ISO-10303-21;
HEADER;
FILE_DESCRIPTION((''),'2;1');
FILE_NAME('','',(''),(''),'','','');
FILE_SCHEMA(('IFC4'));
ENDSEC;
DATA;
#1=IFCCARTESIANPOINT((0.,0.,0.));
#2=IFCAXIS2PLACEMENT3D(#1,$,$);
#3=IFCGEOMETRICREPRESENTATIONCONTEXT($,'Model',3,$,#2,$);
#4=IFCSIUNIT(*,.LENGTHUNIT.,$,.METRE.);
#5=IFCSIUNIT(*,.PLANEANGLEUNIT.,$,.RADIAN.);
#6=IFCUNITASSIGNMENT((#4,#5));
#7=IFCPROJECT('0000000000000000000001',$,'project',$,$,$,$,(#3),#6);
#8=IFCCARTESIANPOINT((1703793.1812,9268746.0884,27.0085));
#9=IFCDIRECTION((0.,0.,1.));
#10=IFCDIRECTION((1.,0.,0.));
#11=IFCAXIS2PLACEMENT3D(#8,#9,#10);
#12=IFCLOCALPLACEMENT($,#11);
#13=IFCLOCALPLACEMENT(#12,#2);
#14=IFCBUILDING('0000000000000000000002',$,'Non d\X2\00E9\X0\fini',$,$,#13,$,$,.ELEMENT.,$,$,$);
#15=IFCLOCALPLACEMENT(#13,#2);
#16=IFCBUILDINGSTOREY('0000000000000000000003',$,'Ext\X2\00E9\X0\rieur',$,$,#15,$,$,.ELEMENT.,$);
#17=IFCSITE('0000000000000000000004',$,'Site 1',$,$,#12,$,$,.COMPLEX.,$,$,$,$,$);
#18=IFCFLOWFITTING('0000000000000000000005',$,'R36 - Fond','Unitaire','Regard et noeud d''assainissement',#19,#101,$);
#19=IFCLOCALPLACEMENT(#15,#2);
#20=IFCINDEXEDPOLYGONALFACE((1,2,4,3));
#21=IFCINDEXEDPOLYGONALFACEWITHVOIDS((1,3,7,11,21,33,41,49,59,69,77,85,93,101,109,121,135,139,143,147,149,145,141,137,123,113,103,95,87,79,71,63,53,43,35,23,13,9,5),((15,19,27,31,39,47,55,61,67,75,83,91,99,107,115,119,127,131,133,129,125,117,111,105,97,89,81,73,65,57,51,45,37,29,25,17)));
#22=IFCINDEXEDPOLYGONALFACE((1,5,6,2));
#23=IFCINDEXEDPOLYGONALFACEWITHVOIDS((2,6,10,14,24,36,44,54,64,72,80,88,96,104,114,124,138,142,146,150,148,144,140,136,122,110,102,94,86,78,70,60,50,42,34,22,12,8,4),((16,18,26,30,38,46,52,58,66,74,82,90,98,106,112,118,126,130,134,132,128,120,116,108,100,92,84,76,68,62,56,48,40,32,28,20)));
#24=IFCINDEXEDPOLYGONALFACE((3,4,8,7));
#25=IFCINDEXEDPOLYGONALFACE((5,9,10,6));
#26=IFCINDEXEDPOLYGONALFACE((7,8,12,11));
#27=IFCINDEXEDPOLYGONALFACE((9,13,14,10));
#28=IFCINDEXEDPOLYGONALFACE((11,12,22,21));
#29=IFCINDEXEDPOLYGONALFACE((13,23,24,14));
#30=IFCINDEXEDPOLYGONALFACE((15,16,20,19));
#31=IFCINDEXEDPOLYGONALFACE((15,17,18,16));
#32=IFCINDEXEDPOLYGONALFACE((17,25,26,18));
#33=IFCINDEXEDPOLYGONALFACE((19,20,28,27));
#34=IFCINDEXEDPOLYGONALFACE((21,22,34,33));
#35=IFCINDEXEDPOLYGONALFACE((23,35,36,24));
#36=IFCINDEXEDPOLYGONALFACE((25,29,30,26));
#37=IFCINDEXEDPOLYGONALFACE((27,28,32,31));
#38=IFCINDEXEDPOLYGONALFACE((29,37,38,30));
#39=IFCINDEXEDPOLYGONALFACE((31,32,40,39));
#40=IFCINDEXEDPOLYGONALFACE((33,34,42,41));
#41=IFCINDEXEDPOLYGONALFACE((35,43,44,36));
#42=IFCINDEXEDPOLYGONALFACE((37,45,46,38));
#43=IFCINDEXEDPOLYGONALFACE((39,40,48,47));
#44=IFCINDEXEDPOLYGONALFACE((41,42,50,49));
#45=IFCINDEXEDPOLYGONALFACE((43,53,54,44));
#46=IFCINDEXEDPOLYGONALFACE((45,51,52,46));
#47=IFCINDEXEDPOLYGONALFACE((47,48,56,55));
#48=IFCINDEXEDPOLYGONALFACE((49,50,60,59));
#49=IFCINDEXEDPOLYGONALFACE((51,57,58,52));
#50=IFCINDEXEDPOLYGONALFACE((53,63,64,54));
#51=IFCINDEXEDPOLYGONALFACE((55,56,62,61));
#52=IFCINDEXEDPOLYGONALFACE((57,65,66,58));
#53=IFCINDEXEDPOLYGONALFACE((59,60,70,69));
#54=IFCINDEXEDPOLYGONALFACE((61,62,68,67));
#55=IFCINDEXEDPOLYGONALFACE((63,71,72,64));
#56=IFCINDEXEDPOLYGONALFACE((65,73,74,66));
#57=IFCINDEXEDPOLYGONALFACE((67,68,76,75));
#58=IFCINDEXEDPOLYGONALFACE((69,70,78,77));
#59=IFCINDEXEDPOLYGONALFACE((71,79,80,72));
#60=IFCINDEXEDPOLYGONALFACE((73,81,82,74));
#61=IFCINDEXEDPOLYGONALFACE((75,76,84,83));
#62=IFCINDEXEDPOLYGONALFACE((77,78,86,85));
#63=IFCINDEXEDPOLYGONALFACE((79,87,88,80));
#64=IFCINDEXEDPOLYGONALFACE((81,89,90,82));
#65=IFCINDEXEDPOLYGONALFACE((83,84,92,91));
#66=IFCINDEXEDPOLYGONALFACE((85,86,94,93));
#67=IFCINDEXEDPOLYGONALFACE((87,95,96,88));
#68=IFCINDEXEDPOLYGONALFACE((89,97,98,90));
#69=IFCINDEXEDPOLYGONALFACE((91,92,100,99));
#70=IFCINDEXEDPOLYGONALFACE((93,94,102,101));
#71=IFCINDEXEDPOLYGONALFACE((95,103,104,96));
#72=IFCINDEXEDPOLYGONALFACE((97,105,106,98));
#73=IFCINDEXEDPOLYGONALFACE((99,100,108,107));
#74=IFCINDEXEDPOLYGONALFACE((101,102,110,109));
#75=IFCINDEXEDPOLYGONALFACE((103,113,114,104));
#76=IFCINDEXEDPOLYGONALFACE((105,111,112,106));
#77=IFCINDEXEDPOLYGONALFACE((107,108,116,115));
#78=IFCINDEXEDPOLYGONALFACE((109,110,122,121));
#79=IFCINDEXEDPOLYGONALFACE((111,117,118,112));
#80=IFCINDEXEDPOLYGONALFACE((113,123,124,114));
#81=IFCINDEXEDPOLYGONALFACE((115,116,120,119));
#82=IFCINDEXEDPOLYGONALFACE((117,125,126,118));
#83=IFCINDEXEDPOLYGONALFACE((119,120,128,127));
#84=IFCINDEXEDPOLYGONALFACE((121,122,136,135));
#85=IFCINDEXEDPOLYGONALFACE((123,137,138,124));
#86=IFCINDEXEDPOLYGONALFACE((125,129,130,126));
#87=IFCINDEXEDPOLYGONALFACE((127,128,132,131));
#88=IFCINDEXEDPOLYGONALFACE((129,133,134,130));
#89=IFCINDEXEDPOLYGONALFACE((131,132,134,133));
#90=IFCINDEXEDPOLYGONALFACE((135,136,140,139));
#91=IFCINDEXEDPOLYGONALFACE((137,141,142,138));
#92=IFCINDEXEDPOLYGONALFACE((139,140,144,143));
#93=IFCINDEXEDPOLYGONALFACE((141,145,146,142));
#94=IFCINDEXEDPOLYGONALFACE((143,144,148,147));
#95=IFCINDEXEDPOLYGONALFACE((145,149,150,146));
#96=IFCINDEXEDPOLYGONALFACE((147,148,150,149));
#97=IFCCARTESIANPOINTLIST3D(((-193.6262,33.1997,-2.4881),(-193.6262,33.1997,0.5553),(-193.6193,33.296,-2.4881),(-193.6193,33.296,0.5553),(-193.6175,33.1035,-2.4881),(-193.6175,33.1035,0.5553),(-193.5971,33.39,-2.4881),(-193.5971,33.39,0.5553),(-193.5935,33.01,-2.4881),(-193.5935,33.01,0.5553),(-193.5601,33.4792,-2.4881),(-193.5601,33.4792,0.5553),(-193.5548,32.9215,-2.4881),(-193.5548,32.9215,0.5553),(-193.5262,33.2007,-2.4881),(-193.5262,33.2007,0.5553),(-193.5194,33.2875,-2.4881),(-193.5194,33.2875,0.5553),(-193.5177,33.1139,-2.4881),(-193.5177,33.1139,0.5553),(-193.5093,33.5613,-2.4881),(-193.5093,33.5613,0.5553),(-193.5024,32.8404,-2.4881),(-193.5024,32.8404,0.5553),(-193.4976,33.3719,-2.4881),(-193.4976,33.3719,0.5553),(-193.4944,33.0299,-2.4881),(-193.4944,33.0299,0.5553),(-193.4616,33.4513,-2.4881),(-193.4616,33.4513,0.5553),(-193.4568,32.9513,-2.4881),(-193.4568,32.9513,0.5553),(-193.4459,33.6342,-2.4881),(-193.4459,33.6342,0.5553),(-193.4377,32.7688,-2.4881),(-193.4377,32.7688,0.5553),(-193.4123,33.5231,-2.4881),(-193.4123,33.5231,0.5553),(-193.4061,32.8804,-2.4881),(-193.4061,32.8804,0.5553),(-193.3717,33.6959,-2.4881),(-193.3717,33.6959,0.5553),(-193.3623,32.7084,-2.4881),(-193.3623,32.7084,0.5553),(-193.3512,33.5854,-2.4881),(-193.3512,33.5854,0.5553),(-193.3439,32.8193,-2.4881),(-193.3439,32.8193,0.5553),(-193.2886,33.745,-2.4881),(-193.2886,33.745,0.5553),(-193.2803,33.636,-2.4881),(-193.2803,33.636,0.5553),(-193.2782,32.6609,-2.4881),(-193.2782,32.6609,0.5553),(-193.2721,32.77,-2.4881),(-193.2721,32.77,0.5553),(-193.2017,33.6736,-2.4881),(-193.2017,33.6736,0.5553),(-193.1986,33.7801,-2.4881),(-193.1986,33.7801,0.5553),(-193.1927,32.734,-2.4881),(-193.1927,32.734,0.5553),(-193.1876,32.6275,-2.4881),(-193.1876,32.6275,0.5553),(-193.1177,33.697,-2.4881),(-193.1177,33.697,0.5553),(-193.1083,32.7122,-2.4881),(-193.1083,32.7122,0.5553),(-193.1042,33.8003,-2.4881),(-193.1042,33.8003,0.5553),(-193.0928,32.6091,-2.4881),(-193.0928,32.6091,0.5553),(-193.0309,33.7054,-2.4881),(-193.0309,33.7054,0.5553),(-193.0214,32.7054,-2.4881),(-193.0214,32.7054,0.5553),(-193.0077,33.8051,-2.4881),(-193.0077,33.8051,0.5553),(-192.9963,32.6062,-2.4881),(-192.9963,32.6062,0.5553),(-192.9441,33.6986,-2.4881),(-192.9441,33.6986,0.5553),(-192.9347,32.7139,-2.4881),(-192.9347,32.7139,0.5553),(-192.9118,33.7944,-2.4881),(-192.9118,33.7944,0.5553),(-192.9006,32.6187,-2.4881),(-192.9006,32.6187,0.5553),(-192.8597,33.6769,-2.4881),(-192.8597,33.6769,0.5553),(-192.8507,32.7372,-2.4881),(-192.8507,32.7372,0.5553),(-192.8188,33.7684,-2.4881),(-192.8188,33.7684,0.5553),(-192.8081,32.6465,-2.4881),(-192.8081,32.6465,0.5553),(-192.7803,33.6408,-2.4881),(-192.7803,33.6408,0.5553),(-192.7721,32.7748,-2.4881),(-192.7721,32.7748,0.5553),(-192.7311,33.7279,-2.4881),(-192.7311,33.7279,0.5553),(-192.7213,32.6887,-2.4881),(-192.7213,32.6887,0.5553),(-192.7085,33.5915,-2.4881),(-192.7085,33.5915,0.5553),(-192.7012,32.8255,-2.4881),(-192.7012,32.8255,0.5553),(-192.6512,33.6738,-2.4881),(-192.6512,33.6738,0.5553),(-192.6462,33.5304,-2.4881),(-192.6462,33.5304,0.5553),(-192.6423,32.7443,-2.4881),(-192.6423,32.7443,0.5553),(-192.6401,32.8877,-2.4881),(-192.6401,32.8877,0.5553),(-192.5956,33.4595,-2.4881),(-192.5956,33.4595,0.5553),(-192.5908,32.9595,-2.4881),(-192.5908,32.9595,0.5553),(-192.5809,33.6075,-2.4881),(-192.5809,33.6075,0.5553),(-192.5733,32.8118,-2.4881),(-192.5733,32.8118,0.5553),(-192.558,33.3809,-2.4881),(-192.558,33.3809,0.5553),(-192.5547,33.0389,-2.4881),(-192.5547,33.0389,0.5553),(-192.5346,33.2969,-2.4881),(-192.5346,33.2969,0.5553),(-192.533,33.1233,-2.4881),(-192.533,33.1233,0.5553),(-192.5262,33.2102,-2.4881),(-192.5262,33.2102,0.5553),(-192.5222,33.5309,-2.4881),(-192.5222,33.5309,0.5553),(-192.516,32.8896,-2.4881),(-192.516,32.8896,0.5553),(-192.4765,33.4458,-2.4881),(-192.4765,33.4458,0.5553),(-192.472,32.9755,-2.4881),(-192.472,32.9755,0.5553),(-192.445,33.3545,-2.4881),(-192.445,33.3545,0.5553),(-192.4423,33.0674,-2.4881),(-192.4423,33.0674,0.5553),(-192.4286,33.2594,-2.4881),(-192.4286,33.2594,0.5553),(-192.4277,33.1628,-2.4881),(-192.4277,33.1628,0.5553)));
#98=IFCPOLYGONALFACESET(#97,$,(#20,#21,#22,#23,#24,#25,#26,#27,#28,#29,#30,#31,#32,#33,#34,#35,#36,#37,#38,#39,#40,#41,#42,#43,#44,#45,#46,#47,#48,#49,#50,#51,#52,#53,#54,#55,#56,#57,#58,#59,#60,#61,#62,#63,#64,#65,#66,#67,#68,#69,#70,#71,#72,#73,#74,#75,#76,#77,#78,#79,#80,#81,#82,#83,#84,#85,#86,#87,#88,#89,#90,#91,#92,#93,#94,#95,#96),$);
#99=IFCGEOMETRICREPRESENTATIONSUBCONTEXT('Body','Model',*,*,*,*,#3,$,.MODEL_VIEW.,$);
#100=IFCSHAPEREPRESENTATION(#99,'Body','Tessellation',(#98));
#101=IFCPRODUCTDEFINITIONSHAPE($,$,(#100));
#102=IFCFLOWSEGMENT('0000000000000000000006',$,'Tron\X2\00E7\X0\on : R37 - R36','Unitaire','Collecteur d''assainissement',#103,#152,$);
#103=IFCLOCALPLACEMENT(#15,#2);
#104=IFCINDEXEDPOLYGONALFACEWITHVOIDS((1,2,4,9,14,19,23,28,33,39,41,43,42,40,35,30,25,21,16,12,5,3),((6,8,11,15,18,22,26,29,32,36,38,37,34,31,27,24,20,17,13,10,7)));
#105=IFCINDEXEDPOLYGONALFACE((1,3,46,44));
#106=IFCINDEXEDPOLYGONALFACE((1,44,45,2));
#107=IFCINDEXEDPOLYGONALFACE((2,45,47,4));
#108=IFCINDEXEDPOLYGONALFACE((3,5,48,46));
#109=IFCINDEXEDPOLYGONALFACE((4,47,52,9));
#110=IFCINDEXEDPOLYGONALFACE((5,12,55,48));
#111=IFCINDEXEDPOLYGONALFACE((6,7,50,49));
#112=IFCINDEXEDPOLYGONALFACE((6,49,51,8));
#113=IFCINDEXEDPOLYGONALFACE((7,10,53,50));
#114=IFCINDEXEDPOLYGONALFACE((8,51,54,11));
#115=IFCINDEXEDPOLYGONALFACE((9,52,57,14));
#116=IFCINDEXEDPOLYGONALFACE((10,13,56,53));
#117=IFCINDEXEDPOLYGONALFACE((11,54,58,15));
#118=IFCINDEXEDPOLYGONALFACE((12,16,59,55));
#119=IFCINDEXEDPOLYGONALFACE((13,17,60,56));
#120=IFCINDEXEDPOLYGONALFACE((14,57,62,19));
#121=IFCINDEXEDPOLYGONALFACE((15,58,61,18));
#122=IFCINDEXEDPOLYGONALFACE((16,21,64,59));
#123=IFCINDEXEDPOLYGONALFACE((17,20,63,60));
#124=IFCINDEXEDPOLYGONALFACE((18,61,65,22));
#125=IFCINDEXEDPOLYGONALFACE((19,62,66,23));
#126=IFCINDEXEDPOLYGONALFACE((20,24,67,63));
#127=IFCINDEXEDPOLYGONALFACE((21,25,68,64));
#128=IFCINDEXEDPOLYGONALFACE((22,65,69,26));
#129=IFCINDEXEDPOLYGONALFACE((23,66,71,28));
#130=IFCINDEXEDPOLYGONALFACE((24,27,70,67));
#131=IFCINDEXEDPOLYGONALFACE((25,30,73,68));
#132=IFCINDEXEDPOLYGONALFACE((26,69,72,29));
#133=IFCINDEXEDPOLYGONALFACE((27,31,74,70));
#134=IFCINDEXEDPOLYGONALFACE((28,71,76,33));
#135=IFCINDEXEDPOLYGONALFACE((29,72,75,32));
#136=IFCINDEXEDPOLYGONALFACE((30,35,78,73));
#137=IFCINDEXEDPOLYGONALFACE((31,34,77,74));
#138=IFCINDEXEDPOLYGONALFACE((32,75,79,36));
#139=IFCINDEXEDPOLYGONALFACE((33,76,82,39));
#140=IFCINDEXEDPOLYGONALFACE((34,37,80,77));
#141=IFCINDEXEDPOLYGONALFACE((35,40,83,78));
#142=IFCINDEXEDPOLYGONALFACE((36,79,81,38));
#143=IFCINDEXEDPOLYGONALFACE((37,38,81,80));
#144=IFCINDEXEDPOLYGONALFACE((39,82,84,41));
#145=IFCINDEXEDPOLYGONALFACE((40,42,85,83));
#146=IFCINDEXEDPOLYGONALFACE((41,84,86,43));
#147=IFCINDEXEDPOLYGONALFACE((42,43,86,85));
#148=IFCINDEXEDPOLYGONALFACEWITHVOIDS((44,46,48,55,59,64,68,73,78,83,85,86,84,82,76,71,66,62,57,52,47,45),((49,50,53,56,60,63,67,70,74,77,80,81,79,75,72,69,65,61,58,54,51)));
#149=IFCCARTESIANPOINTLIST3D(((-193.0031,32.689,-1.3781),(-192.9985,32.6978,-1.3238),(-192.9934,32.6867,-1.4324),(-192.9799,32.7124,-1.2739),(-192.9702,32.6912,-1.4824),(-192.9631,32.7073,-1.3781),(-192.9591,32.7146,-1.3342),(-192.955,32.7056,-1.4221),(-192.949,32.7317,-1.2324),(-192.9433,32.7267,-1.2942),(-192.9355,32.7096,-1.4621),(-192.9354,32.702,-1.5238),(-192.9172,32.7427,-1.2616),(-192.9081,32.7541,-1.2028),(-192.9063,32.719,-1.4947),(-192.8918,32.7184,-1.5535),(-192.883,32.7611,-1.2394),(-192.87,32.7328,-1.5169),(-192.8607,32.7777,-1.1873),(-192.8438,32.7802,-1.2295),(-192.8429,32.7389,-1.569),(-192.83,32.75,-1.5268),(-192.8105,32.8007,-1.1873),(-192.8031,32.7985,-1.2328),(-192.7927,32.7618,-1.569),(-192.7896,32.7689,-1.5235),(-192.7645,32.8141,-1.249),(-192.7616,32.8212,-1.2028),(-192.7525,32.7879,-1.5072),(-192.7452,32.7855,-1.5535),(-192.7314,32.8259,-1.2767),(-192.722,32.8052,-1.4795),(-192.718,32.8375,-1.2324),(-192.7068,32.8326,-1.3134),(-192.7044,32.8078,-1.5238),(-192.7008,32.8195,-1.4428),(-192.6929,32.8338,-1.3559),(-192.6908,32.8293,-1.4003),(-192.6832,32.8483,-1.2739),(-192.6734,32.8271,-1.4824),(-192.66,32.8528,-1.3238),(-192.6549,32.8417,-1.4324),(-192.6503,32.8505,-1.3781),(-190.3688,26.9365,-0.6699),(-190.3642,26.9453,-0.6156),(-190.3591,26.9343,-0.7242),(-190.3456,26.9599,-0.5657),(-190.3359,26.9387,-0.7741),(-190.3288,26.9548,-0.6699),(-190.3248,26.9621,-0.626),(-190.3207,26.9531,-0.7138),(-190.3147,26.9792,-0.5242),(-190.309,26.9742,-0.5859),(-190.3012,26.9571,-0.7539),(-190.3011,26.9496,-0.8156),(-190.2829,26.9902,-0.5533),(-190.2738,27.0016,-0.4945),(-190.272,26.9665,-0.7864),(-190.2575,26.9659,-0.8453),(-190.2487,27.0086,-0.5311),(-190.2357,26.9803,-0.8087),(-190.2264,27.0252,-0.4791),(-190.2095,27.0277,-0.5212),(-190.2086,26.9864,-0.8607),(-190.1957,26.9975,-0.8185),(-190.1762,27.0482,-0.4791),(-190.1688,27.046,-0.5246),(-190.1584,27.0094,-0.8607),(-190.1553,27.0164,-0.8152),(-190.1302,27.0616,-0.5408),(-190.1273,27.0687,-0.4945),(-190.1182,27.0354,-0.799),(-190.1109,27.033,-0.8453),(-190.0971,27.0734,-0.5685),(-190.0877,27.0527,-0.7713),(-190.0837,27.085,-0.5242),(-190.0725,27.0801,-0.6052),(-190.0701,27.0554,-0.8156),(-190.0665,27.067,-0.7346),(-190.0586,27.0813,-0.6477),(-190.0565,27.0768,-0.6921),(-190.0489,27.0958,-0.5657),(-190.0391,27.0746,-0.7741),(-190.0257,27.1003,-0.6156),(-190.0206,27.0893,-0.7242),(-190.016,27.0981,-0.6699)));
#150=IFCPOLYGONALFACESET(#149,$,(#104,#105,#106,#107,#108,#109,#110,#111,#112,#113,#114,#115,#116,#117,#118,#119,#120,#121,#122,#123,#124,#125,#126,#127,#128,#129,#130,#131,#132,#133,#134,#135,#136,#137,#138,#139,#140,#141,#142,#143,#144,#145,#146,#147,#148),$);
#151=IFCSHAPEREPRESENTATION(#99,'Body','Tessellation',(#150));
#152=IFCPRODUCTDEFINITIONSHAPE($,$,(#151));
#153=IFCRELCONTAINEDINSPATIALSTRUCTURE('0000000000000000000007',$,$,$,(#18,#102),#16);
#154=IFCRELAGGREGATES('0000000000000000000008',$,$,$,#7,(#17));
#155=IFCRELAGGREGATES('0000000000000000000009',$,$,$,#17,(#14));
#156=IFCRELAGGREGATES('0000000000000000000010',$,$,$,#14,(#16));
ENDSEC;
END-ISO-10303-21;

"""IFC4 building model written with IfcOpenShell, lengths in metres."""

from ifc_helpers import new_model, si_unit, frame, origin, origin_2d, place, context, subcontext, project, spatial, hollow_circle, extrude, element, save


model = new_model("IFC4")

# Units and contexts
model_context = context("Model", 3, world=origin())
body_context = subcontext(model_context, "Body", "Model", "MODEL_VIEW")
ifc_project = project(units=[si_unit("LENGTHUNIT", "METRE"), si_unit("PLANEANGLEUNIT", "RADIAN")], contexts=[model_context])

# Site, building, storey
site_placement = place(None, frame((1703793.1812, 9268746.0884, 27.0085), z_axis=(0.0, 0.0, 1.0), x_axis=(1.0, 0.0, 0.0)))
site = spatial("IfcSite", under=ifc_project, at=site_placement, Name="Site 1", CompositionType="COMPLEX")
building_placement = place(site_placement, origin())
building = spatial("IfcBuilding", under=site, at=building_placement, Name="Non défini", CompositionType="ELEMENT")
storey_placement = place(building_placement, origin())
storey = spatial("IfcBuildingStorey", under=building, at=storey_placement, Name="Extérieur", CompositionType="ELEMENT")

# Flow fitting
flow_fitting_1_placement = place(storey_placement, origin())
element("IfcFlowFitting", 1, at=flow_fitting_1_placement, inside=storey, Name="R36 - Fond", Description="Unitaire", ObjectType="Regard et noeud d'assainissement", context=body_context, shape_type="SweptSolid", body=[
    extrude(hollow_circle(Radius=0.6, WallThickness=0.1, at=origin_2d()), frame((-193.0262, 33.2054, -2.4881), z_axis=(0.0, 0.0, 1.0), x_axis=(0.508219, -0.861228, 0.0)), (0.0, 0.0, 1.0), 3.0434),
])

# Flow segment
flow_segment_1_placement = place(storey_placement, origin())
element("IfcFlowSegment", 2, at=flow_segment_1_placement, inside=storey, Name="Tronçon : R37 - R36", Description="Unitaire", ObjectType="Collecteur d'assainissement", context=body_context, shape_type="SweptSolid", body=[
    extrude(hollow_circle(Radius=0.194, WallThickness=0.044, at=origin_2d()), frame((-190.1924, 27.0173, -0.6699), z_axis=(-0.413776, 0.903556, -0.111244), x_axis=(-0.9092, -0.416361, 0.0)), (0.0, 0.0, 1.0), 6.3665),
])

save(model, "model.ifc")
